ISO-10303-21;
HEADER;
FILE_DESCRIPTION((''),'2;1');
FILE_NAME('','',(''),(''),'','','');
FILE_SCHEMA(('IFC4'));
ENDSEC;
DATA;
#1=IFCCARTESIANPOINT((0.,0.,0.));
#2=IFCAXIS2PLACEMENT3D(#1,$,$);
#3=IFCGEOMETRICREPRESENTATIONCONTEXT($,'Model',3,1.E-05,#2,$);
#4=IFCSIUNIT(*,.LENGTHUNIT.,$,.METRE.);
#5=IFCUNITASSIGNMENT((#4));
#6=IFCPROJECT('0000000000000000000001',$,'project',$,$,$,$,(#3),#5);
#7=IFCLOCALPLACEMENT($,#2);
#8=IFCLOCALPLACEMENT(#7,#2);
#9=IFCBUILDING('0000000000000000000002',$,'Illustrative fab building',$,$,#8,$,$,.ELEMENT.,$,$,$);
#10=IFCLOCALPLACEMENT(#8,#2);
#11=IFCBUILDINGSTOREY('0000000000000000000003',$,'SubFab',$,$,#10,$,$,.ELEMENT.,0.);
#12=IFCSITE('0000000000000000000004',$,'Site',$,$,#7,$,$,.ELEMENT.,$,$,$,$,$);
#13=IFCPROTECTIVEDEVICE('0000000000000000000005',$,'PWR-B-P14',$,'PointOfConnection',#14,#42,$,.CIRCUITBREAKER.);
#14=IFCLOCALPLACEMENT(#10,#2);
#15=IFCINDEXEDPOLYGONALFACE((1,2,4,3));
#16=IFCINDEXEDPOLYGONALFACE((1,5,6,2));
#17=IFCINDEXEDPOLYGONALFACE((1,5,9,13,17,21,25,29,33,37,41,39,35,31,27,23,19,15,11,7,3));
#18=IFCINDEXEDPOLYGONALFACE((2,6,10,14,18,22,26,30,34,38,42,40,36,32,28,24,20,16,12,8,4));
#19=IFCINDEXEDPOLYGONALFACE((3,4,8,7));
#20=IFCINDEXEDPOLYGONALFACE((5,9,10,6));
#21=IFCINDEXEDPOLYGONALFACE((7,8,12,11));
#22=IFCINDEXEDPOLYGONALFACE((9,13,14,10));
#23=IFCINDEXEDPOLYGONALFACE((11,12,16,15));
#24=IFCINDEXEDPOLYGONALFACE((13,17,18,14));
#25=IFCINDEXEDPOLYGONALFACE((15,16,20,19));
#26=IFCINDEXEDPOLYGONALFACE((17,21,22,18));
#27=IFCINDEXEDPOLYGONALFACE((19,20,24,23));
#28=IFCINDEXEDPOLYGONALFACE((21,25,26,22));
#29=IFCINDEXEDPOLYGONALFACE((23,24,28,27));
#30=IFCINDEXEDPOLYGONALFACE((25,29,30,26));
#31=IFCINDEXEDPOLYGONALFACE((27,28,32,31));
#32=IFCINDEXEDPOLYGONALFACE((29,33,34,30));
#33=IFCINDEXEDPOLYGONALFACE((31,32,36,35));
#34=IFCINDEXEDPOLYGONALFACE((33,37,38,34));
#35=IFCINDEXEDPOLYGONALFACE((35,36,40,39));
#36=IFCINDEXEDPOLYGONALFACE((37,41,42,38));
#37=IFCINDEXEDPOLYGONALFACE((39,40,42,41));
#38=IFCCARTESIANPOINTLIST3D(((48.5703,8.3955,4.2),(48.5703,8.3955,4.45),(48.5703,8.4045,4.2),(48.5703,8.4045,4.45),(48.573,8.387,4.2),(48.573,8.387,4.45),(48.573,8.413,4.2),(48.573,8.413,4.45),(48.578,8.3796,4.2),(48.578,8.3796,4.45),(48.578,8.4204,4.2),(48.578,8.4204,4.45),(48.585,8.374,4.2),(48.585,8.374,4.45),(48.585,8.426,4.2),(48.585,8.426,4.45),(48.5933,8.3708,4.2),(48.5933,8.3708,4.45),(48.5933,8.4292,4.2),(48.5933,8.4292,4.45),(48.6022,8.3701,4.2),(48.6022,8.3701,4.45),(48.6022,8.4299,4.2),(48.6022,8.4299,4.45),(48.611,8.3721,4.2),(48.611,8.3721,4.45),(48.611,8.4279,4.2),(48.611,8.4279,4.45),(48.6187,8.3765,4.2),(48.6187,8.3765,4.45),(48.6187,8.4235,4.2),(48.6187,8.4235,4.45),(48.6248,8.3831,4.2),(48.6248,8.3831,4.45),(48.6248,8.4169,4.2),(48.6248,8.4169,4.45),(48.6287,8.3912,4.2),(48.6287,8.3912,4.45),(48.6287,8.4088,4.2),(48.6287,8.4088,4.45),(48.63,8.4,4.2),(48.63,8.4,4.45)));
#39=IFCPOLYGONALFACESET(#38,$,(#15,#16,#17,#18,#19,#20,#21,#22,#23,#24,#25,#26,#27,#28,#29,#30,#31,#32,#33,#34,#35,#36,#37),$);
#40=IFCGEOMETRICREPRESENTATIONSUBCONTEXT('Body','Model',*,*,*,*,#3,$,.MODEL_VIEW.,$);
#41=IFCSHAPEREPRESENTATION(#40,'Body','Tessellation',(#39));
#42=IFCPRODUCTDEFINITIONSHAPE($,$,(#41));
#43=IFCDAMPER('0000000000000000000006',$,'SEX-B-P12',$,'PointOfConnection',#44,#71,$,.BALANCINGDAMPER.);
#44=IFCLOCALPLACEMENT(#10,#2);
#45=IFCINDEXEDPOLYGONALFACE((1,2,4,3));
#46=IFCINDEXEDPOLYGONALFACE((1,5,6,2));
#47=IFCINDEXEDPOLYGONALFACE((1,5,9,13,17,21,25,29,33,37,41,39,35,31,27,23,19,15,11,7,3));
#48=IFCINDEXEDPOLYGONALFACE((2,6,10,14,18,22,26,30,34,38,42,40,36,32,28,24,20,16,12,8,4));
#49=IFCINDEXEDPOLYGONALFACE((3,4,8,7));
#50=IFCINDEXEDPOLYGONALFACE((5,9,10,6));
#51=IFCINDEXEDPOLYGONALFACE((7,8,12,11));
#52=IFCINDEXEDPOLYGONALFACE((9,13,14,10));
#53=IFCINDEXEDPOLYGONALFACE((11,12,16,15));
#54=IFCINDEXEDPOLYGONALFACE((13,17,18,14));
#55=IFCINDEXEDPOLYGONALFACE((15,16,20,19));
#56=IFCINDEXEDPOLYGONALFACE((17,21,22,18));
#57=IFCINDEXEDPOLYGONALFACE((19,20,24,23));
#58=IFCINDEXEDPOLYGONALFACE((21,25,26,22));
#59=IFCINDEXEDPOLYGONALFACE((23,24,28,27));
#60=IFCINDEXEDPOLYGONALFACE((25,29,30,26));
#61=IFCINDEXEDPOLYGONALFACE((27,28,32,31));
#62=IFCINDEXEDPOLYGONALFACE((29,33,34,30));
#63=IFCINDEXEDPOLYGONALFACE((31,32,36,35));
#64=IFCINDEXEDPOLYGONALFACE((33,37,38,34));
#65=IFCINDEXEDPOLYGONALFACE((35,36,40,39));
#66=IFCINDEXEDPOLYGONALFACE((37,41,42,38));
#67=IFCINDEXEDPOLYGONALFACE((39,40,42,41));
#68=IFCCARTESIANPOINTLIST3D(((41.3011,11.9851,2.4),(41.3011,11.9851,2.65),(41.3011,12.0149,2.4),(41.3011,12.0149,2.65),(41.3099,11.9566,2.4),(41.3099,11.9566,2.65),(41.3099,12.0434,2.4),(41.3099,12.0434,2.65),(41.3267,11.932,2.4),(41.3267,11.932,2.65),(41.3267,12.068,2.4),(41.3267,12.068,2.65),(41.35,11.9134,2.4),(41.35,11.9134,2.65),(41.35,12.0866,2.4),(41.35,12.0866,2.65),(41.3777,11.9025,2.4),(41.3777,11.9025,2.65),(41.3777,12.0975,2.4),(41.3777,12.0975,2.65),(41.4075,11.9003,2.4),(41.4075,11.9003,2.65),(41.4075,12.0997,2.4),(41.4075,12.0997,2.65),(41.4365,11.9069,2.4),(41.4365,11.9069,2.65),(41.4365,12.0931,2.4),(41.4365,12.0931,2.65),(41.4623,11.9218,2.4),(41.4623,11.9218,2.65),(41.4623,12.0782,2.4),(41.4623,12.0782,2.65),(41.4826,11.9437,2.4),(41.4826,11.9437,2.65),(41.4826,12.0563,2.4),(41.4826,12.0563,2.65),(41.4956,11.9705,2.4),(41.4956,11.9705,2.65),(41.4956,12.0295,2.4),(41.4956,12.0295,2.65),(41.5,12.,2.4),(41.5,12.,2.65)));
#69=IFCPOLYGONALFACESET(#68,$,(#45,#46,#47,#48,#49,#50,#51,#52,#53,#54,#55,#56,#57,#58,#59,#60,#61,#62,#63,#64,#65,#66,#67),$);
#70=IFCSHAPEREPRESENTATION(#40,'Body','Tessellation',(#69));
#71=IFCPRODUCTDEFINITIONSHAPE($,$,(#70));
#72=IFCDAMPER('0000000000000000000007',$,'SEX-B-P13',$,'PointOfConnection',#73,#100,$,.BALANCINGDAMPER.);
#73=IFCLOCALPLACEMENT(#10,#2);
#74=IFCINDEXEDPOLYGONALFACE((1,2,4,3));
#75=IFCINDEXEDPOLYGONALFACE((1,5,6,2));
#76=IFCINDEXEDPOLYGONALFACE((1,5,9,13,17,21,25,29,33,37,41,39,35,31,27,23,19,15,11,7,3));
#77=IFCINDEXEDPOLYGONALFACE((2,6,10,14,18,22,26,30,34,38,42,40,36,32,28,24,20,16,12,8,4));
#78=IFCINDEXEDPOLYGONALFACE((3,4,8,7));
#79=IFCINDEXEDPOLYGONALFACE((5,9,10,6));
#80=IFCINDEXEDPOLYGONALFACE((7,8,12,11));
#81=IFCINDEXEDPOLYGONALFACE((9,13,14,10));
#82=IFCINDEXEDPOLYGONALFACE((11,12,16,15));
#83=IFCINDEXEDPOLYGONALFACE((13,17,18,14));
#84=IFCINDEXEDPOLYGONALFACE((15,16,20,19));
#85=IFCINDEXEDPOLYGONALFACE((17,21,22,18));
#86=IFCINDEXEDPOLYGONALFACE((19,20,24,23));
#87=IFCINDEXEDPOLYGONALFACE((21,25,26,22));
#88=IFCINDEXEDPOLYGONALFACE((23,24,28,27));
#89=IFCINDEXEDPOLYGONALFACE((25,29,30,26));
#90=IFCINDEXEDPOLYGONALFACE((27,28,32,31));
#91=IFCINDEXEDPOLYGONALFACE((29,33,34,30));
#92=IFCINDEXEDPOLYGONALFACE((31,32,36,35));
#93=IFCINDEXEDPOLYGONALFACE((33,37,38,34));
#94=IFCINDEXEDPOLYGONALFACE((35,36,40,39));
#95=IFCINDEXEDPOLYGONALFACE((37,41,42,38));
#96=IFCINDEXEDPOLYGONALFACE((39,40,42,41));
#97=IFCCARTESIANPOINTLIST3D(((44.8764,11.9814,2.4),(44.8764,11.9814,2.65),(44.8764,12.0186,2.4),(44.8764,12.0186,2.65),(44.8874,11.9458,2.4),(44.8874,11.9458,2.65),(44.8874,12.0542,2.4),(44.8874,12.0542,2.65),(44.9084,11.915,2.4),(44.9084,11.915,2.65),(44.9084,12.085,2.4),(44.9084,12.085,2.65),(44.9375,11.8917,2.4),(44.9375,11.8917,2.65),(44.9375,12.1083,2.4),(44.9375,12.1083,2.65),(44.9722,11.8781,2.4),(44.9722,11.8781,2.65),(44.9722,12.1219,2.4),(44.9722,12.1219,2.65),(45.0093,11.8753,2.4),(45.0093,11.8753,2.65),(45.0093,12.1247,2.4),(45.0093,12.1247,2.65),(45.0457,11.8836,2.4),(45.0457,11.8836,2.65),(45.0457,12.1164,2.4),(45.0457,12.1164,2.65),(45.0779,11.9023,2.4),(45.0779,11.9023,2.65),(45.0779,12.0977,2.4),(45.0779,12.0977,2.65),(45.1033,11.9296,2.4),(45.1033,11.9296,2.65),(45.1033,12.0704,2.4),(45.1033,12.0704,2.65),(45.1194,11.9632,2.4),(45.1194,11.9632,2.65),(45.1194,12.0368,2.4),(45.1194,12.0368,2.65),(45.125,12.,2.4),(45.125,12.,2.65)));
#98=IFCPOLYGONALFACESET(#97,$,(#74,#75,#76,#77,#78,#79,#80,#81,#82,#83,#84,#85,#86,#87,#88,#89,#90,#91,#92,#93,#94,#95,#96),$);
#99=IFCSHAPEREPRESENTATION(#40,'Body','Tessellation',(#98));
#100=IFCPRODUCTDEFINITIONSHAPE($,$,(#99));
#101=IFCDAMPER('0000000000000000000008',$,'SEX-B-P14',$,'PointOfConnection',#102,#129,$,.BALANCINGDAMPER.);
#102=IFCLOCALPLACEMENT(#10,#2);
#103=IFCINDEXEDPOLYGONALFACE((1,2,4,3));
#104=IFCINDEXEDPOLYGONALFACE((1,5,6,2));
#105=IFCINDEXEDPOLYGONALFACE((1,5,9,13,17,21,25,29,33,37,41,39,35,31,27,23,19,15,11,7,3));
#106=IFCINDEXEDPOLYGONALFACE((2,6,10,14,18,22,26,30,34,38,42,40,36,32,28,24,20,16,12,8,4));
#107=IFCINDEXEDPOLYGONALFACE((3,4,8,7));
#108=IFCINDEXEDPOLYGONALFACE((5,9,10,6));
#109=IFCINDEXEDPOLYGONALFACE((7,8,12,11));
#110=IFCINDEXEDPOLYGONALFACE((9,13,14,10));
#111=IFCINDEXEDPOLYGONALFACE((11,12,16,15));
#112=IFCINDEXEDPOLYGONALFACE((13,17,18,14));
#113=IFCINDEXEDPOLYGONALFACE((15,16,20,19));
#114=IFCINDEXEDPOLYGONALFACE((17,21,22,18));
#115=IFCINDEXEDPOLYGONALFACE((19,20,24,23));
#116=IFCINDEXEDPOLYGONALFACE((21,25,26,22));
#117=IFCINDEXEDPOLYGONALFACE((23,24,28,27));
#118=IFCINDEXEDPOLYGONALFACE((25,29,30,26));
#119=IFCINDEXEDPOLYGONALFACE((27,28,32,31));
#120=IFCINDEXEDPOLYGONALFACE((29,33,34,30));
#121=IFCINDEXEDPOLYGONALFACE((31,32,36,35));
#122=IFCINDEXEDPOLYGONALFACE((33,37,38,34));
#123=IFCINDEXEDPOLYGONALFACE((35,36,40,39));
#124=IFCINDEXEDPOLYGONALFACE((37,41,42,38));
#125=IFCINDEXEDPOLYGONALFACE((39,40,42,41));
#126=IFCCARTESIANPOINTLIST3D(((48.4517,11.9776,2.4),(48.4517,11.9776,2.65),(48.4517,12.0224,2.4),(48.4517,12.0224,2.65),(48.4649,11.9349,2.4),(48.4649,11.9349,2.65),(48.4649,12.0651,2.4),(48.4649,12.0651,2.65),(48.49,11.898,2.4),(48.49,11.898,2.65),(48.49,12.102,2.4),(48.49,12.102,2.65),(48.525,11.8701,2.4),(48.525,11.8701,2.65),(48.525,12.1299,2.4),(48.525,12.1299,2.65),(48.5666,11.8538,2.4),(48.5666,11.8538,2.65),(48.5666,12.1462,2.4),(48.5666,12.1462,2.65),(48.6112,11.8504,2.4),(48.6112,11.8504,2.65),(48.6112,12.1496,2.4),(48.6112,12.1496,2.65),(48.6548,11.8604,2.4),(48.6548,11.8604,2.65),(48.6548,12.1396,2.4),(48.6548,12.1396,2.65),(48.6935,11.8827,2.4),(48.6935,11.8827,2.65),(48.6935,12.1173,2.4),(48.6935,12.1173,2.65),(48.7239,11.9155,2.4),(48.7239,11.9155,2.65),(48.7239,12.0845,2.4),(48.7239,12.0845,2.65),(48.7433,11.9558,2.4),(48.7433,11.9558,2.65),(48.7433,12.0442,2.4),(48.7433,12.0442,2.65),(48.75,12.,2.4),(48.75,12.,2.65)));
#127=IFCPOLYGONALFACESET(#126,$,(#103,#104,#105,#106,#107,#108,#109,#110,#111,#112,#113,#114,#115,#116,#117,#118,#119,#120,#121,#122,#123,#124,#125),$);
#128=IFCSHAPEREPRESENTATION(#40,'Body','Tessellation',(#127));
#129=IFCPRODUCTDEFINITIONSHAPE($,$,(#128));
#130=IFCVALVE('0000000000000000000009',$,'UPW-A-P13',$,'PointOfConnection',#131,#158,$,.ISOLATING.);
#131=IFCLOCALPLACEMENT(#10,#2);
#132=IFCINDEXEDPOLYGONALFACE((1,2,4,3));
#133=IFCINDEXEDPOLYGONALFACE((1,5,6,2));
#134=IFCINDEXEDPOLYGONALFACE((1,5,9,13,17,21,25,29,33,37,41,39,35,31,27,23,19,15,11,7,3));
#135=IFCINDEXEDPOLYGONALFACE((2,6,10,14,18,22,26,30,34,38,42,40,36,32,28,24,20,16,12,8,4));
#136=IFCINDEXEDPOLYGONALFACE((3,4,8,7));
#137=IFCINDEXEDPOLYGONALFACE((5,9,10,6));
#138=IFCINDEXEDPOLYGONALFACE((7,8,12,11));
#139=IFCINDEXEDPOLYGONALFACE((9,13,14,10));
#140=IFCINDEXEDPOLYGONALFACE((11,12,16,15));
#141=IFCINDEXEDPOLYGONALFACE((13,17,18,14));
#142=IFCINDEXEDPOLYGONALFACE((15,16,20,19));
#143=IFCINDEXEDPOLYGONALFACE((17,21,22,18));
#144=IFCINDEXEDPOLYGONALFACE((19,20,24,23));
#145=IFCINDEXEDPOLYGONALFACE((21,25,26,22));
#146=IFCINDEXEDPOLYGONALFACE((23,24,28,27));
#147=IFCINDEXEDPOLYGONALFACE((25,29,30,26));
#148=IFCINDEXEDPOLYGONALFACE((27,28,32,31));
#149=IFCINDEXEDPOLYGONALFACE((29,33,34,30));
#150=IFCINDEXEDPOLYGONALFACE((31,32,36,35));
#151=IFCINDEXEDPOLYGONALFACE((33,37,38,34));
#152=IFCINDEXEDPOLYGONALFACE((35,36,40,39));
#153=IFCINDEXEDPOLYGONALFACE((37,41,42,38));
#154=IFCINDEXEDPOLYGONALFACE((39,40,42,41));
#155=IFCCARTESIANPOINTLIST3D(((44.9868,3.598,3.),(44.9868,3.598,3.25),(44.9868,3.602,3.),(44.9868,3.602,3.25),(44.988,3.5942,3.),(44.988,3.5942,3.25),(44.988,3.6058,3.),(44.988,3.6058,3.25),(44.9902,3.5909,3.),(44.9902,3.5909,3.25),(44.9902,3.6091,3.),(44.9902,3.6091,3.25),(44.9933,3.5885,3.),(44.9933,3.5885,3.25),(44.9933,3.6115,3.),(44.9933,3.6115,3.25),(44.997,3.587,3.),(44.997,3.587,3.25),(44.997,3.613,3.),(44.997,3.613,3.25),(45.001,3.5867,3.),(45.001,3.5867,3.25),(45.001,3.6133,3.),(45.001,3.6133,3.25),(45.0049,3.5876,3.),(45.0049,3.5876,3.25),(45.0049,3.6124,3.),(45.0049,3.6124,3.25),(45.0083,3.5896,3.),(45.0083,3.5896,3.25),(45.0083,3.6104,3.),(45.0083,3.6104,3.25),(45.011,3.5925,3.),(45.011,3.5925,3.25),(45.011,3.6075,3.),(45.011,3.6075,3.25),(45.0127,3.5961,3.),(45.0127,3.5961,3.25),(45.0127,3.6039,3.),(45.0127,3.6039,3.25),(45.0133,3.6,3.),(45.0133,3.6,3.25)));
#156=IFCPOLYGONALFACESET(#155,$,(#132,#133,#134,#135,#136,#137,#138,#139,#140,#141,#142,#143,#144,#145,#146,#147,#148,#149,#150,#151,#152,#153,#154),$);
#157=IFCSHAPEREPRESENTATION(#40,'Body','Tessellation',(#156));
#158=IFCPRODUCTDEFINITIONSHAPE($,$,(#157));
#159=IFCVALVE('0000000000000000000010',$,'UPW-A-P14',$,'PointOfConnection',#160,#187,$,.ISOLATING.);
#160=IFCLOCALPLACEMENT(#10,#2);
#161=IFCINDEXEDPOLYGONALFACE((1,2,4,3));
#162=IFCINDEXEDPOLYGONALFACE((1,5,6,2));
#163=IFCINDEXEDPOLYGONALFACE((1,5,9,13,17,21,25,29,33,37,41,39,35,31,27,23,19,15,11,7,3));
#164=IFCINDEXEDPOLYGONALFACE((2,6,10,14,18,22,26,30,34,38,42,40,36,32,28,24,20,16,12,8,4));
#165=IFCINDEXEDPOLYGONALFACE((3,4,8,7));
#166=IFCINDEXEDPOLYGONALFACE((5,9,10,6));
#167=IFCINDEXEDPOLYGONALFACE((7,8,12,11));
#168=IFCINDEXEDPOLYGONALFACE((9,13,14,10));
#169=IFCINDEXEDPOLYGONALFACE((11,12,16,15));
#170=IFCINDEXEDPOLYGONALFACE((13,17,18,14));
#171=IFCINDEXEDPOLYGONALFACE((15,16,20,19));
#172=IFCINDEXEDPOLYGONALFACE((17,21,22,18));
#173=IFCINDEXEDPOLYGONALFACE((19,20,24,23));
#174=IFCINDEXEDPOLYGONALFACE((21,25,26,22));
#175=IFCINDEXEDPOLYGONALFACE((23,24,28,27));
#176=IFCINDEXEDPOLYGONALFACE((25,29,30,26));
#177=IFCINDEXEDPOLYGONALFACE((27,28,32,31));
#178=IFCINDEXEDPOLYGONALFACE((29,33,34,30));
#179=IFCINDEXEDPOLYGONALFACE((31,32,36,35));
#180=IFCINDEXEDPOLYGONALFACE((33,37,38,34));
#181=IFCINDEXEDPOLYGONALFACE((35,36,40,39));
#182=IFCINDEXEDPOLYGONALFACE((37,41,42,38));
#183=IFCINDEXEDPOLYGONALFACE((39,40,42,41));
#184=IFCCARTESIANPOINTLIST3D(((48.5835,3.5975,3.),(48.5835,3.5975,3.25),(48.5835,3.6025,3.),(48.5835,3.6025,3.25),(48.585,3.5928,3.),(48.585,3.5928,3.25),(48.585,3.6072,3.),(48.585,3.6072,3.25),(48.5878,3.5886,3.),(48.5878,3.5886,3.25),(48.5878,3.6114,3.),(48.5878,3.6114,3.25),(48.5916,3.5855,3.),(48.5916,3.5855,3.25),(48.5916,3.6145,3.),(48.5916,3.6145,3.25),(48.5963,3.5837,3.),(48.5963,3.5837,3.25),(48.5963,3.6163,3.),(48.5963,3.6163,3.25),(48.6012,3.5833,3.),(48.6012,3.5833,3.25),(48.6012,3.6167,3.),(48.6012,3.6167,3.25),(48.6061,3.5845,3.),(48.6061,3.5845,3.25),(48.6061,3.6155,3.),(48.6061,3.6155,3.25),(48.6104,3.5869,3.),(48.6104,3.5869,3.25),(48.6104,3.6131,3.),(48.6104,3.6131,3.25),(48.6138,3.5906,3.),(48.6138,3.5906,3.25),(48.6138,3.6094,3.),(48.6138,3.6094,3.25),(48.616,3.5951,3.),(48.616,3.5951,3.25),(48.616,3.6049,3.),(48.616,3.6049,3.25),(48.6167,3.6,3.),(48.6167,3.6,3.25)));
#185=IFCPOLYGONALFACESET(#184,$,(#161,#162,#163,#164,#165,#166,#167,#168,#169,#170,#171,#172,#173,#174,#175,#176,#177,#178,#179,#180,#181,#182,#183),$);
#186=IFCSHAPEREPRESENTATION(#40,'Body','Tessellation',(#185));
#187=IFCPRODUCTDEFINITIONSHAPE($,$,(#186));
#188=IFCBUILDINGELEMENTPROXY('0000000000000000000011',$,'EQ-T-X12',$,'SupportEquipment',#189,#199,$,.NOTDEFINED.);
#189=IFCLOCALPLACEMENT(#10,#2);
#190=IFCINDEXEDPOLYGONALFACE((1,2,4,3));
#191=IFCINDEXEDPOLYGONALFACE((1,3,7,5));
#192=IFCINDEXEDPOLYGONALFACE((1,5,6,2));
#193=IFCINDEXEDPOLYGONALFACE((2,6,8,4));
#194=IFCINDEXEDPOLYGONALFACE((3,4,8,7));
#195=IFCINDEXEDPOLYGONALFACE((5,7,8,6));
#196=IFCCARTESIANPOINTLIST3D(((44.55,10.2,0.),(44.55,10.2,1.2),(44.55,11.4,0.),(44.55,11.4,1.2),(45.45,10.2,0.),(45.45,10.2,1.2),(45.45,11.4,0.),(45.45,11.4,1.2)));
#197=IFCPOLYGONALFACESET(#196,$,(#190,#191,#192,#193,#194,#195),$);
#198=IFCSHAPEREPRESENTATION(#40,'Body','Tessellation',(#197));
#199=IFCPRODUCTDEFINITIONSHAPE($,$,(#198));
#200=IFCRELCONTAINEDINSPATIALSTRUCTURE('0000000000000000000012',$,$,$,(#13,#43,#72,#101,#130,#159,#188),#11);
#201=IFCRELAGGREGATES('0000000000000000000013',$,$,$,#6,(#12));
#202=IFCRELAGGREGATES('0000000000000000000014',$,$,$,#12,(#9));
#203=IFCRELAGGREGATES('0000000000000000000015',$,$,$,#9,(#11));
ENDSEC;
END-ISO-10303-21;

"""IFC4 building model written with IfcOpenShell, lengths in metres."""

from ifc_helpers import new_model, entity, si_unit, frame, origin, origin_2d, place, context, subcontext, project, spatial, rectangle, extrude, element, save


model = new_model("IFC4")

# Units and contexts
model_context = context("Model", 3, precision=1e-05, world=origin())
body_context = subcontext(model_context, "Body", "Model", "MODEL_VIEW")
ifc_project = project(units=[si_unit("LENGTHUNIT", "METRE")], contexts=[model_context])

# Site, building, storey
site_placement = place(None, origin())
site = spatial("IfcSite", under=ifc_project, at=site_placement, Name="Site", CompositionType="ELEMENT")
building_placement = place(site_placement, origin())
building = spatial("IfcBuilding", under=site, at=building_placement, Name="Illustrative fab building", CompositionType="ELEMENT")
storey_placement = place(building_placement, origin())
storey = spatial("IfcBuildingStorey", under=building, at=storey_placement, Name="SubFab", CompositionType="ELEMENT", Elevation=0.0)

# Protective device
for number, where, name in (
    (1, (48.6, 8.4, 4.2), "PWR-B-P14"),
):
    element("IfcProtectiveDevice", number, at=place(storey_placement, frame(where)), inside=storey, Name=name, ObjectType="PointOfConnection", PredefinedType="CIRCUITBREAKER", context=body_context, shape_type="AdvancedSweptSolid", body=[
        entity("IfcSweptDiskSolid", entity("IfcPolyline", [entity("IfcCartesianPoint", [0.0, 0.0, 0.0]), entity("IfcCartesianPoint", [0.0, 0.0, 0.25])]), 0.03),
    ])

# Dampers
damper_1_placement = place(storey_placement, frame((41.4, 12.0, 2.4)))
element("IfcDamper", 2, at=damper_1_placement, inside=storey, Name="SEX-B-P12", ObjectType="PointOfConnection", PredefinedType="BALANCINGDAMPER", context=body_context, shape_type="AdvancedSweptSolid", body=[
    entity("IfcSweptDiskSolid", entity("IfcPolyline", [entity("IfcCartesianPoint", [0.0, 0.0, 0.0]), entity("IfcCartesianPoint", [0.0, 0.0, 0.25])]), 0.1),
])
damper_2_placement = place(storey_placement, frame((45.0, 12.0, 2.4)))
element("IfcDamper", 3, at=damper_2_placement, inside=storey, Name="SEX-B-P13", ObjectType="PointOfConnection", PredefinedType="BALANCINGDAMPER", context=body_context, shape_type="AdvancedSweptSolid", body=[
    entity("IfcSweptDiskSolid", entity("IfcPolyline", [entity("IfcCartesianPoint", [0.0, 0.0, 0.0]), entity("IfcCartesianPoint", [0.0, 0.0, 0.25])]), 0.125),
])
damper_3_placement = place(storey_placement, frame((48.6, 12.0, 2.4)))
element("IfcDamper", 4, at=damper_3_placement, inside=storey, Name="SEX-B-P14", ObjectType="PointOfConnection", PredefinedType="BALANCINGDAMPER", context=body_context, shape_type="AdvancedSweptSolid", body=[
    entity("IfcSweptDiskSolid", entity("IfcPolyline", [entity("IfcCartesianPoint", [0.0, 0.0, 0.0]), entity("IfcCartesianPoint", [0.0, 0.0, 0.25])]), 0.15),
])

# Valves
valve_1_placement = place(storey_placement, frame((45.0, 3.6, 3.0)))
element("IfcValve", 5, at=valve_1_placement, inside=storey, Name="UPW-A-P13", ObjectType="PointOfConnection", PredefinedType="ISOLATING", context=body_context, shape_type="AdvancedSweptSolid", body=[
    entity("IfcSweptDiskSolid", entity("IfcPolyline", [entity("IfcCartesianPoint", [0.0, 0.0, 0.0]), entity("IfcCartesianPoint", [0.0, 0.0, 0.25])]), 0.0133),
])
valve_2_placement = place(storey_placement, frame((48.6, 3.6, 3.0)))
element("IfcValve", 6, at=valve_2_placement, inside=storey, Name="UPW-A-P14", ObjectType="PointOfConnection", PredefinedType="ISOLATING", context=body_context, shape_type="AdvancedSweptSolid", body=[
    entity("IfcSweptDiskSolid", entity("IfcPolyline", [entity("IfcCartesianPoint", [0.0, 0.0, 0.0]), entity("IfcCartesianPoint", [0.0, 0.0, 0.25])]), 0.0167),
])

# Building element proxy
proxy_1_placement = place(storey_placement, frame((45.0, 10.8, 0.0)))
element("IfcBuildingElementProxy", 7, at=proxy_1_placement, inside=storey, Name="EQ-T-X12", ObjectType="SupportEquipment", PredefinedType="NOTDEFINED", context=body_context, shape_type="SweptSolid", body=[
    extrude(rectangle(XDim=0.9, YDim=1.2, at=origin_2d()), origin(), (0.0, 0.0, 1.0), 1.2),
])

save(model, "model.ifc")
